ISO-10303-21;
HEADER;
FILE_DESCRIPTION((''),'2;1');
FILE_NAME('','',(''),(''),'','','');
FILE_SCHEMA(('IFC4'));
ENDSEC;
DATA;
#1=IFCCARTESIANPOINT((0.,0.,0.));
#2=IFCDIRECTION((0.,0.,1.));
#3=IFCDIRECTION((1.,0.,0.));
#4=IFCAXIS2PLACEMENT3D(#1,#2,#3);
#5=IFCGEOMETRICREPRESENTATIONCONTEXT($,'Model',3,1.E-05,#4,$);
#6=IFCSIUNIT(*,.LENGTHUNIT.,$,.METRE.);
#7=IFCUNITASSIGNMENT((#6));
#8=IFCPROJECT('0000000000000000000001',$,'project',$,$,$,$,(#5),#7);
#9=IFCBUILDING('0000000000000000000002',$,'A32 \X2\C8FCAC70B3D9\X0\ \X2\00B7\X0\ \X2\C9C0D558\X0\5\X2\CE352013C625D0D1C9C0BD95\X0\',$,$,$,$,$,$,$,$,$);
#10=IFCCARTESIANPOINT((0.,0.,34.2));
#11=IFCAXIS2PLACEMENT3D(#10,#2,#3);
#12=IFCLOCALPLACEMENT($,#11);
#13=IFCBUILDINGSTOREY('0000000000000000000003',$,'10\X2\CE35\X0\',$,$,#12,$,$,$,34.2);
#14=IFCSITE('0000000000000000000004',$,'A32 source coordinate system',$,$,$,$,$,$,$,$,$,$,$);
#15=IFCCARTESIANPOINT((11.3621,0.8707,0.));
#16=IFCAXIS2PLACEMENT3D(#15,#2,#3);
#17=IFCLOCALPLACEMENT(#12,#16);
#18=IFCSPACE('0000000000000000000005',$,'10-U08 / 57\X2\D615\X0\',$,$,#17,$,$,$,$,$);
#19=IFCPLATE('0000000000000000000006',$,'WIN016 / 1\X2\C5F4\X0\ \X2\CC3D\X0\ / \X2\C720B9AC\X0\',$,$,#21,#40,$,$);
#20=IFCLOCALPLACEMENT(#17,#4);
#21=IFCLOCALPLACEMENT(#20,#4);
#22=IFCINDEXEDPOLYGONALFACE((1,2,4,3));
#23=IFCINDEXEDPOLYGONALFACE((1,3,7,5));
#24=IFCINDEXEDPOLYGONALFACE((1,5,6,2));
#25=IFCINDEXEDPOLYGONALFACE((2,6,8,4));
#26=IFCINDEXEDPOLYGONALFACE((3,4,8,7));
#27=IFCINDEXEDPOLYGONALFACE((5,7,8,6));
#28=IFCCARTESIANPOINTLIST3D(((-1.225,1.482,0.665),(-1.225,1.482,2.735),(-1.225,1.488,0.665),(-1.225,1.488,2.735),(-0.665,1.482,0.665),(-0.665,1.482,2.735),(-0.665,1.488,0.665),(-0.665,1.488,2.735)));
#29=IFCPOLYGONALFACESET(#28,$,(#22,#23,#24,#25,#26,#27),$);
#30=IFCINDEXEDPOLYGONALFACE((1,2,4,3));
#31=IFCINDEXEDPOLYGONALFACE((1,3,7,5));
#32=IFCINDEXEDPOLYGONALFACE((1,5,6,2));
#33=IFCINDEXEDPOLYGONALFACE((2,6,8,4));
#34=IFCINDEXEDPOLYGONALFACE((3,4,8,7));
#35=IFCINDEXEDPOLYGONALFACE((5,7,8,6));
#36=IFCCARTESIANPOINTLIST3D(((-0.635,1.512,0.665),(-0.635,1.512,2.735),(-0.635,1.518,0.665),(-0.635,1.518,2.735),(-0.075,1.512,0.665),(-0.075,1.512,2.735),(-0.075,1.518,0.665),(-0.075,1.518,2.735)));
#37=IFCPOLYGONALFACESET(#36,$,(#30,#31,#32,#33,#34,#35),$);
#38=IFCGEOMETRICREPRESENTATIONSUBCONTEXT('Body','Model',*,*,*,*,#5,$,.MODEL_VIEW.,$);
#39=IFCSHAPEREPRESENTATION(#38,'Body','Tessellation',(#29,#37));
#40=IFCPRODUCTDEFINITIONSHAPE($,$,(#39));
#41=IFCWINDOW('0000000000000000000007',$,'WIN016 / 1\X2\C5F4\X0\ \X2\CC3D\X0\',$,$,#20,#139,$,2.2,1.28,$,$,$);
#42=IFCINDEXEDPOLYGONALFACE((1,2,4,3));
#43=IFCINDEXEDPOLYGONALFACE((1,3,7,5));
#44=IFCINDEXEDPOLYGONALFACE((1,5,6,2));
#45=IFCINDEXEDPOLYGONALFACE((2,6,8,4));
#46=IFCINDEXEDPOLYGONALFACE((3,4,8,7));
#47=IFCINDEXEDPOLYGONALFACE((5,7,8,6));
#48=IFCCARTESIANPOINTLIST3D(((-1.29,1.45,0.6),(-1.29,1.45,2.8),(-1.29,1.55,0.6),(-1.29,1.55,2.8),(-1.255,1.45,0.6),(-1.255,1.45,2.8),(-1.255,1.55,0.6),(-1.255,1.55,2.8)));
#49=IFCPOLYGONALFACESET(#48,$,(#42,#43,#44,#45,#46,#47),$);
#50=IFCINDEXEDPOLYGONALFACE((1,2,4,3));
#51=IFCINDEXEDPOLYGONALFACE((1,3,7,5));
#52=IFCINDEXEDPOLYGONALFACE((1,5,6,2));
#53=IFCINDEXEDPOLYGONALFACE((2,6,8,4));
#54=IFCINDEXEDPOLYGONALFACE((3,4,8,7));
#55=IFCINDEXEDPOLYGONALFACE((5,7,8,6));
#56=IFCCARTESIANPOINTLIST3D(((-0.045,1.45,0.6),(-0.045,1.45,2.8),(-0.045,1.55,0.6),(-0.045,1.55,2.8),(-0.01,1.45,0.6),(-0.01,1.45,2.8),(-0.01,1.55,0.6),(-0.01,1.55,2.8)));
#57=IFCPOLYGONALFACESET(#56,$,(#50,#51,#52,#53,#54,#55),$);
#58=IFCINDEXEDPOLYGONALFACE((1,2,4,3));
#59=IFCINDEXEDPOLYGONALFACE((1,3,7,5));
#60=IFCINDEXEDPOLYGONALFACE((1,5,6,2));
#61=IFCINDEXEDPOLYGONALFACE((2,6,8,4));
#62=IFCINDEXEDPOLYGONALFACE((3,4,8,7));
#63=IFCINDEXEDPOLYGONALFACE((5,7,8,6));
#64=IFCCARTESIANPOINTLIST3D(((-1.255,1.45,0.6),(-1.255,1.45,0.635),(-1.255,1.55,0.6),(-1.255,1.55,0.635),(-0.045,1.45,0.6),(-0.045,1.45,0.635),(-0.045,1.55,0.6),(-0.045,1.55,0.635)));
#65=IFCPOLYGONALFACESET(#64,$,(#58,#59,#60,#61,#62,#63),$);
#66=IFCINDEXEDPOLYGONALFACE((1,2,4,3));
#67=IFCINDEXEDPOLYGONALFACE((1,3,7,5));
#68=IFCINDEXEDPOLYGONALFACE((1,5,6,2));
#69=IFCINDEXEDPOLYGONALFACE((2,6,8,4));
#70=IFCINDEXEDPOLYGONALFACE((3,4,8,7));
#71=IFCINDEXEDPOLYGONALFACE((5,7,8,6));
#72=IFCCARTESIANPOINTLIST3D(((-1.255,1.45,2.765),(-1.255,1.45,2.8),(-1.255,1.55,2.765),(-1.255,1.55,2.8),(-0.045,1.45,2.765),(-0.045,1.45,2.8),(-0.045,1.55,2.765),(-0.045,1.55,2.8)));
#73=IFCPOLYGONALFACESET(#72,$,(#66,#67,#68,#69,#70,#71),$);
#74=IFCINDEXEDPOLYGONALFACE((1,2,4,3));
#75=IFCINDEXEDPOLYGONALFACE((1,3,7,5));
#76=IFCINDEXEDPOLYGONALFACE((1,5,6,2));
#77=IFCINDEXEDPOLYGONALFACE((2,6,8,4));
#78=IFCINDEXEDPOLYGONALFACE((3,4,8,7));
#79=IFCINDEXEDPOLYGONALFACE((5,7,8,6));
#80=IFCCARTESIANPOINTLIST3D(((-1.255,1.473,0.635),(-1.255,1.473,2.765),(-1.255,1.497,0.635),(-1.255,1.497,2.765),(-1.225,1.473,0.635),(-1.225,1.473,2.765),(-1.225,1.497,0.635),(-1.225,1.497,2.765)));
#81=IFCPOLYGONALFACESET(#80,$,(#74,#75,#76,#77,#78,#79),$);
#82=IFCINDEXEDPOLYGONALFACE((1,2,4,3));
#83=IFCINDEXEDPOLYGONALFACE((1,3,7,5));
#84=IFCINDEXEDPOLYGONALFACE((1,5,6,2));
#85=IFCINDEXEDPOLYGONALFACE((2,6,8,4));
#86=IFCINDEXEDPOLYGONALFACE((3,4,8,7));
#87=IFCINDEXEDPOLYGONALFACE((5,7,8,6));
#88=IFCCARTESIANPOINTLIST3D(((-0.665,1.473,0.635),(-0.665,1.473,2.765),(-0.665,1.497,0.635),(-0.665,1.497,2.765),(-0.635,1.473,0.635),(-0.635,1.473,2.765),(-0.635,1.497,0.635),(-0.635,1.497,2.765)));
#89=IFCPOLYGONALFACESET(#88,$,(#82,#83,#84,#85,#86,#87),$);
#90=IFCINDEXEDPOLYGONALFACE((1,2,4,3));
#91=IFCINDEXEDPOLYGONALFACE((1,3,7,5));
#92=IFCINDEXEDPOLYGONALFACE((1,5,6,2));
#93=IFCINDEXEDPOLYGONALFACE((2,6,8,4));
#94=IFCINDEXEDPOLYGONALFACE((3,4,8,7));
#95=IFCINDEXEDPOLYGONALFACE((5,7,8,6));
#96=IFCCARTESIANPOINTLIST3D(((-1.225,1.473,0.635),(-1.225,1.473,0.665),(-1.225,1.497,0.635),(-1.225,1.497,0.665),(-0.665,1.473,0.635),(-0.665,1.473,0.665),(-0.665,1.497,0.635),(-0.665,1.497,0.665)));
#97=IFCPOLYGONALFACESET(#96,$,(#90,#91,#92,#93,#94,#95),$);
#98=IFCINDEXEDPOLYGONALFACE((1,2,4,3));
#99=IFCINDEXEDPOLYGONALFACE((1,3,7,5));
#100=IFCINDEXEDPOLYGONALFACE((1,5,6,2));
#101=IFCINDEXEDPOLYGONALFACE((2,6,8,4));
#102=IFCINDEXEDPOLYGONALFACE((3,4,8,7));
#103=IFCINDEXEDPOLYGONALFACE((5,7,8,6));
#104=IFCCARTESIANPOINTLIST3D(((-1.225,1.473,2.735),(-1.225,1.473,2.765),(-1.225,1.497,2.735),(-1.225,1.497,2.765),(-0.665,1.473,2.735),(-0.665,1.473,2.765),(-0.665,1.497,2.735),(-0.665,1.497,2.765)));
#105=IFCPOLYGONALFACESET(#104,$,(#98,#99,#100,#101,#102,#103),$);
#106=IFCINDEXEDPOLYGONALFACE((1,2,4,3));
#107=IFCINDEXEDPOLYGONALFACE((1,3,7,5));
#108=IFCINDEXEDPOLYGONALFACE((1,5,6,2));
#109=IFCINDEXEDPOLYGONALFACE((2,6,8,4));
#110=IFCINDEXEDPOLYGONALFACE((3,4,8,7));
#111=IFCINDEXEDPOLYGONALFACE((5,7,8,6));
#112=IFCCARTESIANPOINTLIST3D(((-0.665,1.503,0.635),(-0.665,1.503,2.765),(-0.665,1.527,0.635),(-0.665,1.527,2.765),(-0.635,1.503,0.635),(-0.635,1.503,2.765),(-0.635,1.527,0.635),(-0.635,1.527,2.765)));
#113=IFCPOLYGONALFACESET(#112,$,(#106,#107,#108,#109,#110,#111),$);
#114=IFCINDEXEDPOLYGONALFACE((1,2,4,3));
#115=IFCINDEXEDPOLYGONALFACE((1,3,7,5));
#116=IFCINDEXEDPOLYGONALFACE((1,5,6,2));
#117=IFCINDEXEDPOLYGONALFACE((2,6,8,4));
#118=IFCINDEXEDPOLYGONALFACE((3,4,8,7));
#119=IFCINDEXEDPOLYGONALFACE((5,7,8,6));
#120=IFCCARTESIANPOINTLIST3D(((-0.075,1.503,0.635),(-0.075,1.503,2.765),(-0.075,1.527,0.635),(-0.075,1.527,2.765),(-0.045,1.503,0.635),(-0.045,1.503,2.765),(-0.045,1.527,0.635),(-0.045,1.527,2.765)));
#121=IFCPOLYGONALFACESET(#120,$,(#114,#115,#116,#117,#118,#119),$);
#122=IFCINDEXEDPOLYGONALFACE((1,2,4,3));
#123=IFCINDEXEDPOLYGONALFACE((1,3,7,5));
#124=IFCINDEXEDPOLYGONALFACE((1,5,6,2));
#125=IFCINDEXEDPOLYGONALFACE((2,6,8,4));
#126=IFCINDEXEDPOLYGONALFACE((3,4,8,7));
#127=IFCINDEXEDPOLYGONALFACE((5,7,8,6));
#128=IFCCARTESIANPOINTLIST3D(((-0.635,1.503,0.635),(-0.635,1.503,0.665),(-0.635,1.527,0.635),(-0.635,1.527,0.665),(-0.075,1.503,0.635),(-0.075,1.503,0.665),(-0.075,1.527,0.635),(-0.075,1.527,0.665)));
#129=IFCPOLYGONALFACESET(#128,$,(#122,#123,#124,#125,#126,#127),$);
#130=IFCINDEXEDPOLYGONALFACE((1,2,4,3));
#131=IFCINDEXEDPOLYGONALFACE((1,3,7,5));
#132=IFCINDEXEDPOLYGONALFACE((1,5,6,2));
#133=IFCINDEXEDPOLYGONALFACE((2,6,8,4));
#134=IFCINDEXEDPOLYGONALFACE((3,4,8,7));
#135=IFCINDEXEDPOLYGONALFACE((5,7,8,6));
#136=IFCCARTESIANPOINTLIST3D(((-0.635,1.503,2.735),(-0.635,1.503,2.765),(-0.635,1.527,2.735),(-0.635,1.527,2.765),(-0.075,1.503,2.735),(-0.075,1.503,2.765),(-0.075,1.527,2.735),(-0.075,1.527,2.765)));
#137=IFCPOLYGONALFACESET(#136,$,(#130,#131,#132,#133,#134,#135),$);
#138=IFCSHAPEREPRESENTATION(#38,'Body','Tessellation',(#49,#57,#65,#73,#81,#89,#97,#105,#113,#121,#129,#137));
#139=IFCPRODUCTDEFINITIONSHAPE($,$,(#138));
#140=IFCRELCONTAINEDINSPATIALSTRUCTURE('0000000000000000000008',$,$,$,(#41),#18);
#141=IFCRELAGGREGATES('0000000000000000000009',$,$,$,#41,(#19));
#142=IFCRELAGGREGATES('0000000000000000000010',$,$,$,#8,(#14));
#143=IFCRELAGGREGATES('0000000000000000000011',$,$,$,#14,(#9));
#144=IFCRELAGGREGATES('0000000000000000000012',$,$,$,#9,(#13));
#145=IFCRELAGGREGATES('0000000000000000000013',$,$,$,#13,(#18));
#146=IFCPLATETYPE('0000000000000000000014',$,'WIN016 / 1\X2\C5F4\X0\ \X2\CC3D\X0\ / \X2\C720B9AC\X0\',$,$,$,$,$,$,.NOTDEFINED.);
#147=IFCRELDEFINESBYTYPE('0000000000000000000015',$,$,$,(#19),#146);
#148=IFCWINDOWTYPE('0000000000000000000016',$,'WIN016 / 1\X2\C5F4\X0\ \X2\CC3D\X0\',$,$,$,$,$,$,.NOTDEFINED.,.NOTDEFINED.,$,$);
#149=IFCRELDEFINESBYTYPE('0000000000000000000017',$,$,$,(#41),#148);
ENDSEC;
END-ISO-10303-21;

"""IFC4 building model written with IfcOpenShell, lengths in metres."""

from ifc_helpers import new_model, si_unit, frame, origin, origin_with_axes, place, context, subcontext, project, spatial, polyline, outline, extrude, source, transform, mapped, type_object, type_shapes, element, aggregate, save


model = new_model("IFC4")

# Units and contexts
model_context = context("Model", 3, precision=1e-05, world=origin_with_axes())
body_context = subcontext(model_context, "Body", "Model", "MODEL_VIEW")
ifc_project = project(units=[si_unit("LENGTHUNIT", "METRE")], contexts=[model_context])

# Plate
storey_placement = place(None, frame((0.0, 0.0, 34.2), z_axis=(0.0, 0.0, 1.0), x_axis=(1.0, 0.0, 0.0)))
space_placement = place(storey_placement, frame((11.3621, 0.8707, 0.0), z_axis=(0.0, 0.0, 1.0), x_axis=(1.0, 0.0, 0.0)))
plate_type_1 = type_object("IfcPlateType", Name="WIN016 / 1열 창 / 유리", PredefinedType="NOTDEFINED")
shared_shape_1 = source(origin(), body_context, "Body", "SweptSolid", [
    extrude(outline(polyline([(-1.225, 1.482), (-1.225, 1.488), (-0.665, 1.488), (-0.665, 1.482), (-1.225, 1.482)])), frame((0.0, 0.0, 0.665)), (0.0, 0.0, 1.0), 2.07),
    extrude(outline(polyline([(-0.635, 1.512), (-0.635, 1.518), (-0.075, 1.518), (-0.075, 1.512), (-0.635, 1.512)])), frame((0.0, 0.0, 0.665)), (0.0, 0.0, 1.0), 2.07),
])
type_shapes(plate_type_1, [shared_shape_1])
window_1_placement = place(space_placement, origin_with_axes())
plate_1_placement = place(window_1_placement, origin_with_axes())
plate_1 = element("IfcPlate", 1, at=plate_1_placement, type_object=plate_type_1, Name="WIN016 / 1열 창 / 유리", context=body_context, shape_type="MappedRepresentation", body=[
    mapped(shared_shape_1, transform((0.0, 0.0, 0.0), scale=1.0)),
])

# Site, building, storey, space
site = spatial("IfcSite", under=ifc_project, Name="A32 source coordinate system")
building = spatial("IfcBuilding", under=site, Name="A32 주거동 · 지하5층–옥탑지붕")
storey = spatial("IfcBuildingStorey", under=building, at=storey_placement, Name="10층", Elevation=34.2)
space = spatial("IfcSpace", under=storey, at=space_placement, Name="10-U08 / 57형")

# Window
window_type_1 = type_object("IfcWindowType", Name="WIN016 / 1열 창", PartitioningType="NOTDEFINED", PredefinedType="NOTDEFINED")
shared_shape_2 = source(origin(), body_context, "Body", "SweptSolid", [
    extrude(outline(polyline([(-1.29, 1.45), (-1.29, 1.55), (-1.255, 1.55), (-1.255, 1.45), (-1.29, 1.45)])), frame((0.0, 0.0, 0.6)), (0.0, 0.0, 1.0), 2.2),
    extrude(outline(polyline([(-0.045, 1.45), (-0.045, 1.55), (-0.01, 1.55), (-0.01, 1.45), (-0.045, 1.45)])), frame((0.0, 0.0, 0.6)), (0.0, 0.0, 1.0), 2.2),
    extrude(outline(polyline([(-1.255, 1.45), (-1.255, 1.55), (-0.045, 1.55), (-0.045, 1.45), (-1.255, 1.45)])), frame((0.0, 0.0, 0.6)), (0.0, 0.0, 1.0), 0.035),
    extrude(outline(polyline([(-1.255, 1.45), (-1.255, 1.55), (-0.045, 1.55), (-0.045, 1.45), (-1.255, 1.45)])), frame((0.0, 0.0, 2.765)), (0.0, 0.0, 1.0), 0.035),
    extrude(outline(polyline([(-1.255, 1.473), (-1.255, 1.497), (-1.225, 1.497), (-1.225, 1.473), (-1.255, 1.473)])), frame((0.0, 0.0, 0.635)), (0.0, 0.0, 1.0), 2.13),
    extrude(outline(polyline([(-0.665, 1.473), (-0.665, 1.497), (-0.635, 1.497), (-0.635, 1.473), (-0.665, 1.473)])), frame((0.0, 0.0, 0.635)), (0.0, 0.0, 1.0), 2.13),
    extrude(outline(polyline([(-1.225, 1.473), (-1.225, 1.497), (-0.665, 1.497), (-0.665, 1.473), (-1.225, 1.473)])), frame((0.0, 0.0, 0.635)), (0.0, 0.0, 1.0), 0.03),
    extrude(outline(polyline([(-1.225, 1.473), (-1.225, 1.497), (-0.665, 1.497), (-0.665, 1.473), (-1.225, 1.473)])), frame((0.0, 0.0, 2.735)), (0.0, 0.0, 1.0), 0.03),
    extrude(outline(polyline([(-0.665, 1.503), (-0.665, 1.527), (-0.635, 1.527), (-0.635, 1.503), (-0.665, 1.503)])), frame((0.0, 0.0, 0.635)), (0.0, 0.0, 1.0), 2.13),
    extrude(outline(polyline([(-0.075, 1.503), (-0.075, 1.527), (-0.045, 1.527), (-0.045, 1.503), (-0.075, 1.503)])), frame((0.0, 0.0, 0.635)), (0.0, 0.0, 1.0), 2.13),
    extrude(outline(polyline([(-0.635, 1.503), (-0.635, 1.527), (-0.075, 1.527), (-0.075, 1.503), (-0.635, 1.503)])), frame((0.0, 0.0, 0.635)), (0.0, 0.0, 1.0), 0.03),
    extrude(outline(polyline([(-0.635, 1.503), (-0.635, 1.527), (-0.075, 1.527), (-0.075, 1.503), (-0.635, 1.503)])), frame((0.0, 0.0, 2.735)), (0.0, 0.0, 1.0), 0.03),
])
type_shapes(window_type_1, [shared_shape_2])
window_1 = element("IfcWindow", 2, at=window_1_placement, inside=space, type_object=window_type_1, Name="WIN016 / 1열 창", OverallHeight=2.2, OverallWidth=1.28, context=body_context, shape_type="MappedRepresentation", body=[
    mapped(shared_shape_2, transform((0.0, 0.0, 0.0), scale=1.0)),
])
aggregate(window_1, [plate_1])

save(model, "model.ifc")
